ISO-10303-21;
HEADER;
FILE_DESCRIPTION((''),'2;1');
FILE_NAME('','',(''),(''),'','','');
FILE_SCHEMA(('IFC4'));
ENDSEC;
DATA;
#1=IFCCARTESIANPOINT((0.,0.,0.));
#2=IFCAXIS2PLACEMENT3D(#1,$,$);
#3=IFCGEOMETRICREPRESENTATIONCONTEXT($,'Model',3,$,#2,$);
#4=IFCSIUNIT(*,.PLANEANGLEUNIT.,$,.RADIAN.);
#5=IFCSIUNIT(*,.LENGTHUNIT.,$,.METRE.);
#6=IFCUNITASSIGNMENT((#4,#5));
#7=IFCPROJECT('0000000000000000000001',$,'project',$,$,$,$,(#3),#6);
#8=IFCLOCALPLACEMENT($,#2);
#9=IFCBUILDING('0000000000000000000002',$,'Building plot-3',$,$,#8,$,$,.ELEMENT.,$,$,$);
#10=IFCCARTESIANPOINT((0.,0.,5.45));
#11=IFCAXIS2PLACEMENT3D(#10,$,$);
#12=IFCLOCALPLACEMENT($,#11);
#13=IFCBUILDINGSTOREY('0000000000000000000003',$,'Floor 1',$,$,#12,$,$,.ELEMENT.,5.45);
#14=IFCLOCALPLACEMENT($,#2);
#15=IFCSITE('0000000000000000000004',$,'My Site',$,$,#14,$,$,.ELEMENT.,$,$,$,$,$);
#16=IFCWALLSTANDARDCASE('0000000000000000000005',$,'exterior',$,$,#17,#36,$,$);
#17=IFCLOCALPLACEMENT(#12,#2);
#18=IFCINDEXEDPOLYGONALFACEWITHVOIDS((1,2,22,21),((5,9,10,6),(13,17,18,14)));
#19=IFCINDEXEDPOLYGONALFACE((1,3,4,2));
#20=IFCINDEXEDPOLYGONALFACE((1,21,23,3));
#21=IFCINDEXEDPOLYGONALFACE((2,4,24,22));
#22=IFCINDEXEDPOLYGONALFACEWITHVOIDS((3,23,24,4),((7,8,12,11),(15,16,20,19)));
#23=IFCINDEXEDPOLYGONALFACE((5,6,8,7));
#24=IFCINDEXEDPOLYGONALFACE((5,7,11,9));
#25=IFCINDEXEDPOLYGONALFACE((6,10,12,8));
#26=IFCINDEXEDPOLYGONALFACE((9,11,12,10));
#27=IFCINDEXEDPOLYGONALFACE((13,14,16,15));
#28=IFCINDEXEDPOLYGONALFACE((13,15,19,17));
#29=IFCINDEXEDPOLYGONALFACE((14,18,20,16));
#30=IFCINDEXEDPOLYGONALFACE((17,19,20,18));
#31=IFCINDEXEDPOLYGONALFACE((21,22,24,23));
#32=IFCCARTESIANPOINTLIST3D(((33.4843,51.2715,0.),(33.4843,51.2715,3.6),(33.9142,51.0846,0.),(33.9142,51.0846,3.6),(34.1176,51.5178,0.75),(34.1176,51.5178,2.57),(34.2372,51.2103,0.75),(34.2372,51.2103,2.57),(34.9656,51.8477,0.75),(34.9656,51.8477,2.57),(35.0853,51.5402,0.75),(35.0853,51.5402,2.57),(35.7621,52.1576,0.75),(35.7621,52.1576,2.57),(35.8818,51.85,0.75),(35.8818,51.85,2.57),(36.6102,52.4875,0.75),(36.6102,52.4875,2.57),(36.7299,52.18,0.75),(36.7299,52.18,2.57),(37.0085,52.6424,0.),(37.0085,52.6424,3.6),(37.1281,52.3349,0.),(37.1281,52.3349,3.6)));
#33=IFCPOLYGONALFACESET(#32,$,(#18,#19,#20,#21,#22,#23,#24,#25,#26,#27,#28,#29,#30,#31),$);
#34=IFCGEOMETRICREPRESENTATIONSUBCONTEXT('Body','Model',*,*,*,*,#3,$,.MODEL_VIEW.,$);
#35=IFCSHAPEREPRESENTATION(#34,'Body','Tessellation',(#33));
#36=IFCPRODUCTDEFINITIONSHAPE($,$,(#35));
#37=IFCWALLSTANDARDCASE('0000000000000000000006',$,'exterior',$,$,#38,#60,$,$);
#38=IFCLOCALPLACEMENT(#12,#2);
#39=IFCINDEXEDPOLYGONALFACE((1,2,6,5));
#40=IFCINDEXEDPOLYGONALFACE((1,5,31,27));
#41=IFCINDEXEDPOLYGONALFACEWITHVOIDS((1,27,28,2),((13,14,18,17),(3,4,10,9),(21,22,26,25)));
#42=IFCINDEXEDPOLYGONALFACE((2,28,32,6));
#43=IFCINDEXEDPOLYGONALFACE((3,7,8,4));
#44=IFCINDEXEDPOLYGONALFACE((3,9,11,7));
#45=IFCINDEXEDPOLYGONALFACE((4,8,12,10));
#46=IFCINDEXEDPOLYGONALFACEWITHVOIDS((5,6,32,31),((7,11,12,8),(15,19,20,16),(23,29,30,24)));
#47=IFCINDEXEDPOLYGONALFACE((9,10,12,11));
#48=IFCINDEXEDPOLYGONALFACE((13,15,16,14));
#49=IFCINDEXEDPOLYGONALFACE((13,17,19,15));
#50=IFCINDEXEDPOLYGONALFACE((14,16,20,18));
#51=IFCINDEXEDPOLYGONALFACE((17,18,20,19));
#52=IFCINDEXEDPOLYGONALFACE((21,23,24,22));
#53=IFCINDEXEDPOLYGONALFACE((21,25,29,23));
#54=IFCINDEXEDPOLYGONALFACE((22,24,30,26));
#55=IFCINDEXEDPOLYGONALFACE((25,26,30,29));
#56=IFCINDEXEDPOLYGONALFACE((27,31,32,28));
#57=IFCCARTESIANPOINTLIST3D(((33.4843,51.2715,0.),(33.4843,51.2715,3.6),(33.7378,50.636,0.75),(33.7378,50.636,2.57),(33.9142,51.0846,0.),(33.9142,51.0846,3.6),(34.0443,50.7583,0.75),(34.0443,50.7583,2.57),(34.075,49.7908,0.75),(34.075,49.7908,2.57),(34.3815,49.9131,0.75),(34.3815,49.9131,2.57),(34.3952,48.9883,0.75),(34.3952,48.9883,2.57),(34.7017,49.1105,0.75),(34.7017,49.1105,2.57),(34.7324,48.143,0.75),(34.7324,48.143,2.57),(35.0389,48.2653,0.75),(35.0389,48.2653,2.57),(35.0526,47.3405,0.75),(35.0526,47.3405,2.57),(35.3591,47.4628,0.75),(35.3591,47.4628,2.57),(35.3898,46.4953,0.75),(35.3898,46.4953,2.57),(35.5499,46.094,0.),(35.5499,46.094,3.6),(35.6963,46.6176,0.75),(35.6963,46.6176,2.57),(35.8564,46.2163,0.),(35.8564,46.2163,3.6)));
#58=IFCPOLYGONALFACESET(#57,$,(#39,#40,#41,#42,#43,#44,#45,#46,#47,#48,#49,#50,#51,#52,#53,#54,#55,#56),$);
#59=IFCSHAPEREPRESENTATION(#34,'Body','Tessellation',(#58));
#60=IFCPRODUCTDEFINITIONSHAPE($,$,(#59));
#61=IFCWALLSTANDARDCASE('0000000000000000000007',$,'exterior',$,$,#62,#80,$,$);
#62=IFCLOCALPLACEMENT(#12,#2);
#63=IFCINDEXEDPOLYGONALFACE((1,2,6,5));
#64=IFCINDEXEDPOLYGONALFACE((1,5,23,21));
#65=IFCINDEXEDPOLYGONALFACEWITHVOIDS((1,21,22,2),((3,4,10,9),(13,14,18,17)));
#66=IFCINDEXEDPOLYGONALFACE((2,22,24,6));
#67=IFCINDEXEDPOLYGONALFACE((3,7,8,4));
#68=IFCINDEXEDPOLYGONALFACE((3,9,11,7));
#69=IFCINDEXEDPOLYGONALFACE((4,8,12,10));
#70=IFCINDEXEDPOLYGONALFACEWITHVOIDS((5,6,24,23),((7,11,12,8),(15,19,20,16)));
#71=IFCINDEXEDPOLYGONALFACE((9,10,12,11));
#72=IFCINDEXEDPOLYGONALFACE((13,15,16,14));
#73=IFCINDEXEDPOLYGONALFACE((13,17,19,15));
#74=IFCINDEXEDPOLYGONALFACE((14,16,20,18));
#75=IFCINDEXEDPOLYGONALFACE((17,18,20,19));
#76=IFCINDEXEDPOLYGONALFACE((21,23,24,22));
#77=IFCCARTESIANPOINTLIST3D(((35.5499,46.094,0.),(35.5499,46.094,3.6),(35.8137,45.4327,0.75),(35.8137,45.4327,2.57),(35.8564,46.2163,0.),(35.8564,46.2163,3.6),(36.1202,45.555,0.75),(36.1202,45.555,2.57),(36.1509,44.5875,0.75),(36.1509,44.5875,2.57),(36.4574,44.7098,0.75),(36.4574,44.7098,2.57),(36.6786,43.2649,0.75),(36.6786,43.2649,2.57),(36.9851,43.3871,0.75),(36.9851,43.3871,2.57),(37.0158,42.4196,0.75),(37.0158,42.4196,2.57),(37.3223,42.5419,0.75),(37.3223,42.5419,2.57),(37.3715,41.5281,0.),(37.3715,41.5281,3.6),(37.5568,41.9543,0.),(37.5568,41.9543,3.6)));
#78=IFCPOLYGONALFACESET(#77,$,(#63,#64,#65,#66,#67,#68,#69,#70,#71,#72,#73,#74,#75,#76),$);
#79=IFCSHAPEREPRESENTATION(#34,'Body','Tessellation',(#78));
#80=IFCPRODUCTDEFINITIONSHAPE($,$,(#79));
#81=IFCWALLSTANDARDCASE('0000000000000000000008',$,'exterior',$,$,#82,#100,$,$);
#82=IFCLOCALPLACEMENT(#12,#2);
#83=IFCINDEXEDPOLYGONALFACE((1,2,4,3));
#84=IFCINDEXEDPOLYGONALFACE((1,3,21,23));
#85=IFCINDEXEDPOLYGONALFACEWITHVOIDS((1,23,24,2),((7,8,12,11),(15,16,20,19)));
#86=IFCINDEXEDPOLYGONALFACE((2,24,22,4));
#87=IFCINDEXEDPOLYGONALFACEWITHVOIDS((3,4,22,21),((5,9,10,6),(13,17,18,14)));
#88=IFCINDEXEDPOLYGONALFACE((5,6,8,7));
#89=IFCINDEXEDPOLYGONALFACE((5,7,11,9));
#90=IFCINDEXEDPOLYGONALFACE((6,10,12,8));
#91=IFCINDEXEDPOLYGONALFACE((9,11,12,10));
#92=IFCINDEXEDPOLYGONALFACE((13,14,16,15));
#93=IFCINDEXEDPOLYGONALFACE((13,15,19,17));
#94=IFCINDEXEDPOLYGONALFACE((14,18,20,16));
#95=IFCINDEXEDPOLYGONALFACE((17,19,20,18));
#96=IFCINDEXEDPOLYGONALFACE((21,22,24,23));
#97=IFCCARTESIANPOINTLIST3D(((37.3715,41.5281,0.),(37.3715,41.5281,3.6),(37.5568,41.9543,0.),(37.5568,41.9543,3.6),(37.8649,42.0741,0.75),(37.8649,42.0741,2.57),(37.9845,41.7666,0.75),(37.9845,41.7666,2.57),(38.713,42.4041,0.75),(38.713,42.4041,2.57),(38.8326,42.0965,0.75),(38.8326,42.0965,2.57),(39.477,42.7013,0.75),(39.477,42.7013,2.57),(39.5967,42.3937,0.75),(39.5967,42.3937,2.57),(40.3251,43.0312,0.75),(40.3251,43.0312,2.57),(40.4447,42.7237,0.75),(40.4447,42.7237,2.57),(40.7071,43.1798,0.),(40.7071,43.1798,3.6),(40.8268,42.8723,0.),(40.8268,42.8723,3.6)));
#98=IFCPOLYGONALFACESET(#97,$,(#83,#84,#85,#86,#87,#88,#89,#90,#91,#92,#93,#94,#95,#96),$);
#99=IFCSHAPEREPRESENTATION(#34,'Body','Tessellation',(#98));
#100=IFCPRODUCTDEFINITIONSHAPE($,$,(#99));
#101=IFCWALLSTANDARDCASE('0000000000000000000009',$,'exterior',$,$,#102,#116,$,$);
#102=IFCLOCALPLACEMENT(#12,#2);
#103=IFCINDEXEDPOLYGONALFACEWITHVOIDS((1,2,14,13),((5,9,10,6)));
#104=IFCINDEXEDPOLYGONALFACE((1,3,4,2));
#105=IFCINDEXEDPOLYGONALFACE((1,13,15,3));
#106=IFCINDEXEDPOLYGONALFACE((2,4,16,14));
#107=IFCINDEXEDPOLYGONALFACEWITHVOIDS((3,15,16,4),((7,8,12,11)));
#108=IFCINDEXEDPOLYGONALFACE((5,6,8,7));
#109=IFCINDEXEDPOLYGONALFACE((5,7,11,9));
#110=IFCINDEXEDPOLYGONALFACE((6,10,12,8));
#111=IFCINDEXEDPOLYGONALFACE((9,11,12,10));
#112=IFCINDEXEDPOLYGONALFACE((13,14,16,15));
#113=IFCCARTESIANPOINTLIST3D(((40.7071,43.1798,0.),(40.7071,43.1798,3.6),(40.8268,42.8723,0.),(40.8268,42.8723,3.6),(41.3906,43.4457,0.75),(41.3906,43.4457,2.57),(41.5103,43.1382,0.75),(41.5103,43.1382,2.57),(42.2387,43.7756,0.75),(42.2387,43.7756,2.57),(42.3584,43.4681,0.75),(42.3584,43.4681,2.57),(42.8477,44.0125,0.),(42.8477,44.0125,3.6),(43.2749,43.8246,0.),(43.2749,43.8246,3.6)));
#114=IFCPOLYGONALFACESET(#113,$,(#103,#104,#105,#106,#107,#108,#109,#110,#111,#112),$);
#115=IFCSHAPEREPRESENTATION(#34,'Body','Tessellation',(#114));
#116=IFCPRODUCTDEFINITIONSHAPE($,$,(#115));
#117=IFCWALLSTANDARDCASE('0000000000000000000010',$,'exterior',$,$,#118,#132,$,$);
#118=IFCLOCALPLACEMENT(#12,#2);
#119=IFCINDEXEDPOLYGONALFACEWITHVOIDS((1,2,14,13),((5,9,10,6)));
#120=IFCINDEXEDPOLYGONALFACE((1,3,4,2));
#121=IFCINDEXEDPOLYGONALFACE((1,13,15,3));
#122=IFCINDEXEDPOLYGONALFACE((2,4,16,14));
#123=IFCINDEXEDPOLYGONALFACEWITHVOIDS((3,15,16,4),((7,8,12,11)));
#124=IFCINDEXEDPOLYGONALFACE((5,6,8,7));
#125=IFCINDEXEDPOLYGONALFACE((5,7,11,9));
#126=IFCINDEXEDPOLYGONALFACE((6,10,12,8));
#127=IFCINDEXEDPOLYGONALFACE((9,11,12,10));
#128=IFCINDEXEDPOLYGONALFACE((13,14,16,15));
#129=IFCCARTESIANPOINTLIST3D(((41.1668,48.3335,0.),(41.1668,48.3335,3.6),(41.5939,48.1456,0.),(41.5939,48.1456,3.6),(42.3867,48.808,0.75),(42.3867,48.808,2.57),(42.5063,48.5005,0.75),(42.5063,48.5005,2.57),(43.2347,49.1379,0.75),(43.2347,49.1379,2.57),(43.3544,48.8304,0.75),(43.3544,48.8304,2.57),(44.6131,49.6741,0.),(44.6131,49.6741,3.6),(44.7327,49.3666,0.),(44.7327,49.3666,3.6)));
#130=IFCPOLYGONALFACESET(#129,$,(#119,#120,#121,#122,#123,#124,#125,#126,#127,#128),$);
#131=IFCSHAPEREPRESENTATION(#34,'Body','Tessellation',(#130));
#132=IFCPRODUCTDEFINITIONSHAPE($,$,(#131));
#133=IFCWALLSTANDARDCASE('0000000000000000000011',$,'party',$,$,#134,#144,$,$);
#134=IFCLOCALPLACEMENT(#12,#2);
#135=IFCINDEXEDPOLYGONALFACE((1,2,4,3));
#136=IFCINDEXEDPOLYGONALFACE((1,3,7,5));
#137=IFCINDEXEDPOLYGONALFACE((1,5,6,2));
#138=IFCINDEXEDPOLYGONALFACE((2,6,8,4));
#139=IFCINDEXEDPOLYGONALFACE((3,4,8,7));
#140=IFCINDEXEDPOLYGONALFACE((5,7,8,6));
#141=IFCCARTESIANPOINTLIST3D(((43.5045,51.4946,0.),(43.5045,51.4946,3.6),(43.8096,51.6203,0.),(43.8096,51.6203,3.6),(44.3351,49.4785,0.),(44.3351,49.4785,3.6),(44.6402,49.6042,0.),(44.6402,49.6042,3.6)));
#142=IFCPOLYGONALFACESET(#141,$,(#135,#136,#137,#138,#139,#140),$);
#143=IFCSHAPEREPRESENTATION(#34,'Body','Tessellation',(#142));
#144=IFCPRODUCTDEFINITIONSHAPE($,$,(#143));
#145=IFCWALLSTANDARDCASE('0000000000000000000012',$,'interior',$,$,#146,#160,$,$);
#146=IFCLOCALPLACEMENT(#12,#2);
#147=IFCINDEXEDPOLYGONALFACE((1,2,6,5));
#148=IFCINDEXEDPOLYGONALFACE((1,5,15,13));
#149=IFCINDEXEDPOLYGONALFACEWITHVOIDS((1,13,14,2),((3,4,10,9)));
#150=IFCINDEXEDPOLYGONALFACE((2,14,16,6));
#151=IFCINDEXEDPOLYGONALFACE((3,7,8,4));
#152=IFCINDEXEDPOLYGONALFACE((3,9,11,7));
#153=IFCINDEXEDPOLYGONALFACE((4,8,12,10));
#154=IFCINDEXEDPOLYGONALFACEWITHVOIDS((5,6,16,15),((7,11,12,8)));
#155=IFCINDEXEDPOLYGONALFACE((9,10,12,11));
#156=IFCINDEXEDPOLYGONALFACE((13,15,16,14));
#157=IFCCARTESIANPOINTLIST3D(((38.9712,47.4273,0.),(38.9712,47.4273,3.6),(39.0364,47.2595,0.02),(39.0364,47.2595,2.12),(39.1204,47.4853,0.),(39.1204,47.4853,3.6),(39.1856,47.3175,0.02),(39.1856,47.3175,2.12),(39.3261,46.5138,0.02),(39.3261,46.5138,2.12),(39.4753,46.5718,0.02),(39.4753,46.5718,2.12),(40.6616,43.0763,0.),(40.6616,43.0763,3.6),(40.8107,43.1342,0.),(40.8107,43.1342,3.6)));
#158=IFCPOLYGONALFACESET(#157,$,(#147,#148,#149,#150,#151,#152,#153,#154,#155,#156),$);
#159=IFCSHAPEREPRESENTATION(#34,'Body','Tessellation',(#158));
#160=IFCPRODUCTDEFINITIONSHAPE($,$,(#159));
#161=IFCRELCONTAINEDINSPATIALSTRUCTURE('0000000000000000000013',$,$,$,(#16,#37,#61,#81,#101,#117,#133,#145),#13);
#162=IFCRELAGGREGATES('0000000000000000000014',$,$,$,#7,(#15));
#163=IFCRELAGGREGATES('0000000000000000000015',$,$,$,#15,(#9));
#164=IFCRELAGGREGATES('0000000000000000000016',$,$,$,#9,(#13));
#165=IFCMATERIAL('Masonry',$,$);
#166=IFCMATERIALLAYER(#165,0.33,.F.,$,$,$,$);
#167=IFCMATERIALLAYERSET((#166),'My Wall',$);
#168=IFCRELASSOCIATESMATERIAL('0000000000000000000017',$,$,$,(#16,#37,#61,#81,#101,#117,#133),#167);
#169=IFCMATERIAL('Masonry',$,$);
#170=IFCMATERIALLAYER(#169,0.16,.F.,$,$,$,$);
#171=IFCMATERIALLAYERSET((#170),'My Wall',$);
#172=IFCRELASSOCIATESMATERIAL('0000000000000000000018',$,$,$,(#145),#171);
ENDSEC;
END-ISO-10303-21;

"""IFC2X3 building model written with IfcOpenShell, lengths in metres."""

from ifc_helpers import new_model, si_unit, frame, origin, place, context, subcontext, project, spatial, polyline, outline, extrude, material, layer, layer_set, layer_usage, element, save


model = new_model("IFC2X3")

# Units and contexts
model_context = context("Model", 3, world=origin())
body_context = subcontext(model_context, "Body", "Model", "MODEL_VIEW")
ifc_project = project(units=[si_unit("PLANEANGLEUNIT", "RADIAN"), si_unit("LENGTHUNIT", "METRE")], contexts=[model_context])

# Site, building, storey
site_placement = place(None, origin())
site = spatial("IfcSite", under=ifc_project, at=site_placement, Name="My Site", CompositionType="ELEMENT")
building_placement = place(None, origin())
building = spatial("IfcBuilding", under=site, at=building_placement, Name="Building plot-3", CompositionType="ELEMENT")
storey_placement = place(None, frame((0.0, 0.0, 5.45)))
storey = spatial("IfcBuildingStorey", under=building, at=storey_placement, Name="Floor 1", CompositionType="ELEMENT", Elevation=5.45)

# Walls, openings
ifc_material_1 = material(Name="Masonry")
ifc_layer_1 = layer(ifc_material_1, 0.33, ventilated=False)
ifc_layer_set_1 = layer_set([ifc_layer_1], Name="My Wall")
ifc_layer_usage_1 = layer_usage(ifc_layer_set_1, "AXIS2", "NEGATIVE", 0.08)
wall_1_placement = place(storey_placement, origin())
wall_1 = element("IfcWallStandardCase", 1, at=wall_1_placement, inside=storey, material=ifc_layer_usage_1, Name="exterior", context=body_context, shape_type="SweptSolid", body=[
    extrude(outline(polyline([(37.1281, 52.3349), (37.0085, 52.6424), (33.4843, 51.2715), (33.9142, 51.0846), (37.1281, 52.3349)])), origin(), (0.0, 0.0, 1.0), 3.6),
])
opening_1_placement = place(storey_placement, frame((0.0, 0.0, 0.75)))
element("IfcOpeningElement", 2, at=opening_1_placement, cuts=wall_1, ObjectType="Opening", context=body_context, shape_type="SweptSolid", body=[
    extrude(outline(polyline([(36.6102, 52.4875), (35.7621, 52.1576), (35.8818, 51.85), (36.7299, 52.18), (36.6102, 52.4875)])), origin(), (0.0, 0.0, 1.0), 1.82),
])
opening_2_placement = place(storey_placement, frame((0.0, 0.0, 0.75)))
element("IfcOpeningElement", 3, at=opening_2_placement, cuts=wall_1, ObjectType="Opening", context=body_context, shape_type="SweptSolid", body=[
    extrude(outline(polyline([(34.9656, 51.8477), (34.1176, 51.5178), (34.2372, 51.2103), (35.0853, 51.5402), (34.9656, 51.8477)])), origin(), (0.0, 0.0, 1.0), 1.82),
])
wall_2_placement = place(storey_placement, origin())
wall_2 = element("IfcWallStandardCase", 4, at=wall_2_placement, inside=storey, material=ifc_layer_usage_1, Name="exterior", context=body_context, shape_type="SweptSolid", body=[
    extrude(outline(polyline([(33.9142, 51.0846), (33.4843, 51.2715), (35.5499, 46.094), (35.8564, 46.2163), (33.9142, 51.0846)])), origin(), (0.0, 0.0, 1.0), 3.6),
])
opening_3_placement = place(storey_placement, frame((0.0, 0.0, 0.75)))
element("IfcOpeningElement", 5, at=opening_3_placement, cuts=wall_2, ObjectType="Opening", context=body_context, shape_type="SweptSolid", body=[
    extrude(outline(polyline([(33.7378, 50.636), (34.075, 49.7908), (34.3815, 49.9131), (34.0443, 50.7583), (33.7378, 50.636)])), origin(), (0.0, 0.0, 1.0), 1.82),
])
opening_4_placement = place(storey_placement, frame((0.0, 0.0, 0.75)))
element("IfcOpeningElement", 6, at=opening_4_placement, cuts=wall_2, ObjectType="Opening", context=body_context, shape_type="SweptSolid", body=[
    extrude(outline(polyline([(34.3952, 48.9883), (34.7324, 48.143), (35.0389, 48.2653), (34.7017, 49.1105), (34.3952, 48.9883)])), origin(), (0.0, 0.0, 1.0), 1.82),
])
opening_5_placement = place(storey_placement, frame((0.0, 0.0, 0.75)))
element("IfcOpeningElement", 7, at=opening_5_placement, cuts=wall_2, ObjectType="Opening", context=body_context, shape_type="SweptSolid", body=[
    extrude(outline(polyline([(35.0526, 47.3405), (35.3898, 46.4953), (35.6963, 46.6176), (35.3591, 47.4628), (35.0526, 47.3405)])), origin(), (0.0, 0.0, 1.0), 1.82),
])
wall_3_placement = place(storey_placement, origin())
wall_3 = element("IfcWallStandardCase", 8, at=wall_3_placement, inside=storey, material=ifc_layer_usage_1, Name="exterior", context=body_context, shape_type="SweptSolid", body=[
    extrude(outline(polyline([(35.8564, 46.2163), (35.5499, 46.094), (37.3715, 41.5281), (37.5568, 41.9543), (35.8564, 46.2163)])), origin(), (0.0, 0.0, 1.0), 3.6),
])
opening_6_placement = place(storey_placement, frame((0.0, 0.0, 0.75)))
element("IfcOpeningElement", 9, at=opening_6_placement, cuts=wall_3, ObjectType="Opening", context=body_context, shape_type="SweptSolid", body=[
    extrude(outline(polyline([(35.8137, 45.4327), (36.1509, 44.5875), (36.4574, 44.7098), (36.1202, 45.555), (35.8137, 45.4327)])), origin(), (0.0, 0.0, 1.0), 1.82),
])
opening_7_placement = place(storey_placement, frame((0.0, 0.0, 0.75)))
element("IfcOpeningElement", 10, at=opening_7_placement, cuts=wall_3, ObjectType="Opening", context=body_context, shape_type="SweptSolid", body=[
    extrude(outline(polyline([(36.6786, 43.2649), (37.0158, 42.4196), (37.3223, 42.5419), (36.9851, 43.3871), (36.6786, 43.2649)])), origin(), (0.0, 0.0, 1.0), 1.82),
])
wall_4_placement = place(storey_placement, origin())
wall_4 = element("IfcWallStandardCase", 11, at=wall_4_placement, inside=storey, material=ifc_layer_usage_1, Name="exterior", context=body_context, shape_type="SweptSolid", body=[
    extrude(outline(polyline([(37.5568, 41.9543), (37.3715, 41.5281), (40.8268, 42.8723), (40.7071, 43.1798), (37.5568, 41.9543)])), origin(), (0.0, 0.0, 1.0), 3.6),
])
opening_8_placement = place(storey_placement, frame((0.0, 0.0, 0.75)))
element("IfcOpeningElement", 12, at=opening_8_placement, cuts=wall_4, ObjectType="Opening", context=body_context, shape_type="SweptSolid", body=[
    extrude(outline(polyline([(37.9845, 41.7666), (38.8326, 42.0965), (38.713, 42.4041), (37.8649, 42.0741), (37.9845, 41.7666)])), origin(), (0.0, 0.0, 1.0), 1.82),
])
opening_9_placement = place(storey_placement, frame((0.0, 0.0, 0.75)))
element("IfcOpeningElement", 13, at=opening_9_placement, cuts=wall_4, ObjectType="Opening", context=body_context, shape_type="SweptSolid", body=[
    extrude(outline(polyline([(39.5967, 42.3937), (40.4447, 42.7237), (40.3251, 43.0312), (39.477, 42.7013), (39.5967, 42.3937)])), origin(), (0.0, 0.0, 1.0), 1.82),
])

# Wall, opening
wall_5_placement = place(storey_placement, origin())
wall_5 = element("IfcWallStandardCase", 14, at=wall_5_placement, inside=storey, material=ifc_layer_usage_1, Name="exterior", context=body_context, shape_type="SweptSolid", body=[
    extrude(outline(polyline([(40.7071, 43.1798), (40.8268, 42.8723), (43.2749, 43.8246), (42.8477, 44.0125), (40.7071, 43.1798)])), origin(), (0.0, 0.0, 1.0), 3.6),
])
opening_10_placement = place(storey_placement, frame((0.0, 0.0, 0.75)))
element("IfcOpeningElement", 15, at=opening_10_placement, cuts=wall_5, ObjectType="Opening", context=body_context, shape_type="SweptSolid", body=[
    extrude(outline(polyline([(41.5103, 43.1382), (42.3584, 43.4681), (42.2387, 43.7756), (41.3906, 43.4457), (41.5103, 43.1382)])), origin(), (0.0, 0.0, 1.0), 1.82),
])

# Wall, opening
wall_6_placement = place(storey_placement, origin())
wall_6 = element("IfcWallStandardCase", 16, at=wall_6_placement, inside=storey, material=ifc_layer_usage_1, Name="exterior", context=body_context, shape_type="SweptSolid", body=[
    extrude(outline(polyline([(41.1668, 48.3335), (41.5939, 48.1456), (44.7327, 49.3666), (44.6131, 49.6741), (41.1668, 48.3335)])), origin(), (0.0, 0.0, 1.0), 3.6),
])
opening_11_placement = place(storey_placement, frame((0.0, 0.0, 0.75)))
element("IfcOpeningElement", 17, at=opening_11_placement, cuts=wall_6, ObjectType="Opening", context=body_context, shape_type="SweptSolid", body=[
    extrude(outline(polyline([(42.5063, 48.5005), (43.3544, 48.8304), (43.2347, 49.1379), (42.3867, 48.808), (42.5063, 48.5005)])), origin(), (0.0, 0.0, 1.0), 1.82),
])

# Wall
wall_7_placement = place(storey_placement, origin())
element("IfcWallStandardCase", 18, at=wall_7_placement, inside=storey, material=ifc_layer_usage_1, Name="party", context=body_context, shape_type="SweptSolid", body=[
    extrude(outline(polyline([(44.3351, 49.4785), (44.6402, 49.6042), (43.8096, 51.6203), (43.5045, 51.4946), (44.3351, 49.4785)])), origin(), (0.0, 0.0, 1.0), 3.6),
])

# Wall, opening
ifc_material_2 = material(Name="Masonry")
ifc_layer_2 = layer(ifc_material_2, 0.16, ventilated=False)
ifc_layer_set_2 = layer_set([ifc_layer_2], Name="My Wall")
ifc_layer_usage_2 = layer_usage(ifc_layer_set_2, "AXIS2", "NEGATIVE", 0.08)
wall_8_placement = place(storey_placement, origin())
wall_8 = element("IfcWallStandardCase", 19, at=wall_8_placement, inside=storey, material=ifc_layer_usage_2, Name="interior", context=body_context, shape_type="SweptSolid", body=[
    extrude(outline(polyline([(39.1204, 47.4853), (38.9712, 47.4273), (40.6616, 43.0763), (40.8107, 43.1342), (39.1204, 47.4853)])), origin(), (0.0, 0.0, 1.0), 3.6),
])
opening_12_placement = place(storey_placement, frame((0.0, 0.0, 0.02)))
element("IfcOpeningElement", 20, at=opening_12_placement, cuts=wall_8, ObjectType="Opening", context=body_context, shape_type="SweptSolid", body=[
    extrude(outline(polyline([(39.0364, 47.2595), (39.3261, 46.5138), (39.4753, 46.5718), (39.1856, 47.3175), (39.0364, 47.2595)])), origin(), (0.0, 0.0, 1.0), 2.1),
])

save(model, "model.ifc")
